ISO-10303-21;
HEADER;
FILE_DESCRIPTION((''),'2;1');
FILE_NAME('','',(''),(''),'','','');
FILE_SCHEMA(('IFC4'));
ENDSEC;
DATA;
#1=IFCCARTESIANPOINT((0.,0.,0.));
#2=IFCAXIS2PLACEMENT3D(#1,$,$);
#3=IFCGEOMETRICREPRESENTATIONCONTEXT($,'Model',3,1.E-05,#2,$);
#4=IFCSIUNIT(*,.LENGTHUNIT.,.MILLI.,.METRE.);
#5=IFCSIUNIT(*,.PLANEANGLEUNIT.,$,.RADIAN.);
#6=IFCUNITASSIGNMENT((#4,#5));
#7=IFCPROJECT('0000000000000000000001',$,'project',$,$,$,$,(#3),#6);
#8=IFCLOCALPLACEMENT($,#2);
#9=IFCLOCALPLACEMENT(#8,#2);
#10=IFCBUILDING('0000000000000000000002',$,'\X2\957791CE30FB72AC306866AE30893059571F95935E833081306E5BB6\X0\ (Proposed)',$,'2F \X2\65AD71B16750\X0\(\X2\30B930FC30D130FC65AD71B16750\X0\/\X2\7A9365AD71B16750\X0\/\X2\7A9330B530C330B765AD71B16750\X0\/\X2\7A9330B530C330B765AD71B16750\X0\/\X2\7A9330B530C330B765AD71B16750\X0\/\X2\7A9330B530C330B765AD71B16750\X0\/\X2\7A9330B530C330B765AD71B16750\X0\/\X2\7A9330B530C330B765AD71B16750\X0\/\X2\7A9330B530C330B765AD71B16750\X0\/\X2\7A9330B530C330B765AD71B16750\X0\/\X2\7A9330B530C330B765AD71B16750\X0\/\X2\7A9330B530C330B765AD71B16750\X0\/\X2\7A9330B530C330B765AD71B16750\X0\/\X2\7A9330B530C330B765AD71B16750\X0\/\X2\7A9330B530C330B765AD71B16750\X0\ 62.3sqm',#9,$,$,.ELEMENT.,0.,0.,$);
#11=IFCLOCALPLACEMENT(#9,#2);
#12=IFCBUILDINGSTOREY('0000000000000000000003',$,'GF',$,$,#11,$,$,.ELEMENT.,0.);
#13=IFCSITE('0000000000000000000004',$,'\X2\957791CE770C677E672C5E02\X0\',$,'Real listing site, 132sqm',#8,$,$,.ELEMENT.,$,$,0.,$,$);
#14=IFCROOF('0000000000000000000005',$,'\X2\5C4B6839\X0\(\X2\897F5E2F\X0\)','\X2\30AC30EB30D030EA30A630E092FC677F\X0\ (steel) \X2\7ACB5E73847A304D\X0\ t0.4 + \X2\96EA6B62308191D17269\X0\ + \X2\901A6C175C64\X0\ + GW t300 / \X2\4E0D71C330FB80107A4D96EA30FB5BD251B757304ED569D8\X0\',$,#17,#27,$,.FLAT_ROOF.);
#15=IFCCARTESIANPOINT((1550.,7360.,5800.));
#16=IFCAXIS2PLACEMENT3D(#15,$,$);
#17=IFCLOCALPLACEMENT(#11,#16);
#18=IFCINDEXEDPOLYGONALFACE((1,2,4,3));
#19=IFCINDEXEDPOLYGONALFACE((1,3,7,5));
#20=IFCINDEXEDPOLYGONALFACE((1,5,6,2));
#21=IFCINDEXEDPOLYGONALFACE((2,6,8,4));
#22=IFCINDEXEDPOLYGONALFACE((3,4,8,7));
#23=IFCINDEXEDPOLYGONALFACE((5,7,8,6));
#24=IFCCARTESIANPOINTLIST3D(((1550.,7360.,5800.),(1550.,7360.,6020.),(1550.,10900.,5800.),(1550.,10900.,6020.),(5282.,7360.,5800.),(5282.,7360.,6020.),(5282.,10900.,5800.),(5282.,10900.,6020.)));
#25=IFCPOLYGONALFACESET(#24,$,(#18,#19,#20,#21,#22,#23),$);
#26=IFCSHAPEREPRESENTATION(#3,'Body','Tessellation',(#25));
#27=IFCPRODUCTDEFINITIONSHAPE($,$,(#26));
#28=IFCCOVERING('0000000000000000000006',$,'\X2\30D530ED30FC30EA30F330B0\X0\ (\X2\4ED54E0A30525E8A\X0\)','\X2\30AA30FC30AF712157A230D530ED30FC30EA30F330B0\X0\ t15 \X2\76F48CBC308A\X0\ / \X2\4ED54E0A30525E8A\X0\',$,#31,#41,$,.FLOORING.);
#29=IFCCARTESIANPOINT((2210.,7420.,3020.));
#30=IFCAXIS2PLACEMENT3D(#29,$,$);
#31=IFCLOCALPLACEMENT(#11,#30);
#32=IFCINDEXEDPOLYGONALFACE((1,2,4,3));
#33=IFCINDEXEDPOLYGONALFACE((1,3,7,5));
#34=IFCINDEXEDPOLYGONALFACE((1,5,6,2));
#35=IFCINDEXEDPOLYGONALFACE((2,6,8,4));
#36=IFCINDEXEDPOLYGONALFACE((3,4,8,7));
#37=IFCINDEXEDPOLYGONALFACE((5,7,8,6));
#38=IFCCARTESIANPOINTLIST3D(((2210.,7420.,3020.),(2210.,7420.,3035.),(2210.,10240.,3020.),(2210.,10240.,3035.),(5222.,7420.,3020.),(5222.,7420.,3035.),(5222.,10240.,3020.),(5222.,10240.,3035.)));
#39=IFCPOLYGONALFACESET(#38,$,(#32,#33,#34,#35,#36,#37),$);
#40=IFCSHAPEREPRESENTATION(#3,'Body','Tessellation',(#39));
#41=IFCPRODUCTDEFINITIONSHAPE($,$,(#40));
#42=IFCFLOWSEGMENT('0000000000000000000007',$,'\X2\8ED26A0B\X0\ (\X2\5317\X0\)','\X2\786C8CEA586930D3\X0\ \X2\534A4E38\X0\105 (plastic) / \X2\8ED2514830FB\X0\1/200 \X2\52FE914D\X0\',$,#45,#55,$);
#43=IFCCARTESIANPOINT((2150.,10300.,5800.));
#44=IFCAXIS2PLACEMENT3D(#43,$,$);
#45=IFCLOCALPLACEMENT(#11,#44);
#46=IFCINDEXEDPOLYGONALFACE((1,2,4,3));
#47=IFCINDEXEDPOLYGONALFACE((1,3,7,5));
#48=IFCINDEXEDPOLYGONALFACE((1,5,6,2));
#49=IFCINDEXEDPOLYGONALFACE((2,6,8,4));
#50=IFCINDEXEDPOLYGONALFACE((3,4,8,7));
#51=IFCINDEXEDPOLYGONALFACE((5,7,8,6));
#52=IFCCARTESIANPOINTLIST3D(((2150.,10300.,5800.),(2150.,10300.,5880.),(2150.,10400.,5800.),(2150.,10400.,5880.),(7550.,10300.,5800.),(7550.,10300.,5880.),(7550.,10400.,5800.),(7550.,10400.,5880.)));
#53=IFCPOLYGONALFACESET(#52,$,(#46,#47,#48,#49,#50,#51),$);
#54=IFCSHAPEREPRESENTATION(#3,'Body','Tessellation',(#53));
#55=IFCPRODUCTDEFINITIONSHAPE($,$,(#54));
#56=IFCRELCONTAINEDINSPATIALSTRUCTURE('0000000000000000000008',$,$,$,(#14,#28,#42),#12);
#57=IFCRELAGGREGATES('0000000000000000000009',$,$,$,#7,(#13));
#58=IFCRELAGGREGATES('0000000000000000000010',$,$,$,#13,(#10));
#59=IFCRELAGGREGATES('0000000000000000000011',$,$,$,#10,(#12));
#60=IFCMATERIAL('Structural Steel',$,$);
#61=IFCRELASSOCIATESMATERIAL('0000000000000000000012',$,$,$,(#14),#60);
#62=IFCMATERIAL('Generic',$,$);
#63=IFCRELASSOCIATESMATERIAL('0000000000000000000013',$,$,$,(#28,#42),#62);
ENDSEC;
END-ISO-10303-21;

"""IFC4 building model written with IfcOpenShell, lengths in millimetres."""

from ifc_helpers import new_model, si_unit, frame, frame_2d, origin, place, context, project, spatial, rectangle, extrude, material, element, save


model = new_model("IFC4")

# Units and contexts
model_context = context("Model", 3, precision=1e-05, world=origin())
ifc_project = project(units=[si_unit("LENGTHUNIT", "METRE", prefix="MILLI"), si_unit("PLANEANGLEUNIT", "RADIAN")], contexts=[model_context])

# Site, building, storey
site_placement = place(None, origin())
site = spatial("IfcSite", under=ifc_project, at=site_placement, Name="長野県松本市", ObjectType="Real listing site, 132sqm", CompositionType="ELEMENT", RefElevation=0.0)
building_placement = place(site_placement, origin())
building = spatial("IfcBuilding", under=site, at=building_placement, Name="長野・犬と暮らす土間広めの家 (Proposed)", ObjectType="2F 断熱材(スーパー断熱材/窓断熱材/窓サッシ断熱材/窓サッシ断熱材/窓サッシ断熱材/窓サッシ断熱材/窓サッシ断熱材/窓サッシ断熱材/窓サッシ断熱材/窓サッシ断熱材/窓サッシ断熱材/窓サッシ断熱材/窓サッシ断熱材/窓サッシ断熱材/窓サッシ断熱材 62.3sqm", CompositionType="ELEMENT", ElevationOfRefHeight=0.0, ElevationOfTerrain=0.0)
storey_placement = place(building_placement, origin())
storey = spatial("IfcBuildingStorey", under=building, at=storey_placement, Name="GF", CompositionType="ELEMENT", Elevation=0.0)

# Roof
ifc_material_1 = material(Name="Structural Steel")
for number, where, name in (
    (1, (1550.0, 7360.0, 5800.0), "屋根(西帯)"),
):
    element("IfcRoof", number, at=place(storey_placement, frame(where)), inside=storey, material=ifc_material_1, Name=name, Description="ガルバリウム鋼板 (steel) 立平葺き t0.4 + 雪止め金物 + 通気層 + GW t300 / 不燃・耐積雪・寒冷地仕様", PredefinedType="FLAT_ROOF", context=model_context, shape_type="SweptSolid", body=[
        extrude(rectangle(XDim=3732.0, YDim=3540.0, at=frame_2d((1866.0, 1770.0))), frame((1550.0, 7360.0, 5800.0)), (0.0, 0.0, 1.0), 220.0),
    ])

# Covering
ifc_material_2 = material(Name="Generic")
covering_placement = place(storey_placement, frame((2210.0, 7420.0, 3020.0)))
element("IfcCovering", 2, at=covering_placement, inside=storey, material=ifc_material_2, Name="フローリング (仕上げ床)", Description="オーク無垢フローリング t15 直貼り / 仕上げ床", PredefinedType="FLOORING", context=model_context, shape_type="SweptSolid", body=[
    extrude(rectangle(XDim=3012.0, YDim=2820.0, at=frame_2d((1506.0, 1410.0))), frame((2210.0, 7420.0, 3020.0)), (0.0, 0.0, 1.0), 15.0),
])

# Flow segment
flow_segment_placement = place(storey_placement, frame((2150.0, 10300.0, 5800.0)))
element("IfcFlowSegment", 3, at=flow_segment_placement, inside=storey, material=ifc_material_2, Name="軒樋 (北)", Description="硬質塩ビ 半丸105 (plastic) / 軒先・1/200 勾配", context=model_context, shape_type="SweptSolid", body=[
    extrude(rectangle(XDim=5400.0, YDim=100.0, at=frame_2d((2700.0, 50.0))), frame((2150.0, 10300.0, 5800.0)), (0.0, 0.0, 1.0), 80.0),
])

save(model, "model.ifc")
